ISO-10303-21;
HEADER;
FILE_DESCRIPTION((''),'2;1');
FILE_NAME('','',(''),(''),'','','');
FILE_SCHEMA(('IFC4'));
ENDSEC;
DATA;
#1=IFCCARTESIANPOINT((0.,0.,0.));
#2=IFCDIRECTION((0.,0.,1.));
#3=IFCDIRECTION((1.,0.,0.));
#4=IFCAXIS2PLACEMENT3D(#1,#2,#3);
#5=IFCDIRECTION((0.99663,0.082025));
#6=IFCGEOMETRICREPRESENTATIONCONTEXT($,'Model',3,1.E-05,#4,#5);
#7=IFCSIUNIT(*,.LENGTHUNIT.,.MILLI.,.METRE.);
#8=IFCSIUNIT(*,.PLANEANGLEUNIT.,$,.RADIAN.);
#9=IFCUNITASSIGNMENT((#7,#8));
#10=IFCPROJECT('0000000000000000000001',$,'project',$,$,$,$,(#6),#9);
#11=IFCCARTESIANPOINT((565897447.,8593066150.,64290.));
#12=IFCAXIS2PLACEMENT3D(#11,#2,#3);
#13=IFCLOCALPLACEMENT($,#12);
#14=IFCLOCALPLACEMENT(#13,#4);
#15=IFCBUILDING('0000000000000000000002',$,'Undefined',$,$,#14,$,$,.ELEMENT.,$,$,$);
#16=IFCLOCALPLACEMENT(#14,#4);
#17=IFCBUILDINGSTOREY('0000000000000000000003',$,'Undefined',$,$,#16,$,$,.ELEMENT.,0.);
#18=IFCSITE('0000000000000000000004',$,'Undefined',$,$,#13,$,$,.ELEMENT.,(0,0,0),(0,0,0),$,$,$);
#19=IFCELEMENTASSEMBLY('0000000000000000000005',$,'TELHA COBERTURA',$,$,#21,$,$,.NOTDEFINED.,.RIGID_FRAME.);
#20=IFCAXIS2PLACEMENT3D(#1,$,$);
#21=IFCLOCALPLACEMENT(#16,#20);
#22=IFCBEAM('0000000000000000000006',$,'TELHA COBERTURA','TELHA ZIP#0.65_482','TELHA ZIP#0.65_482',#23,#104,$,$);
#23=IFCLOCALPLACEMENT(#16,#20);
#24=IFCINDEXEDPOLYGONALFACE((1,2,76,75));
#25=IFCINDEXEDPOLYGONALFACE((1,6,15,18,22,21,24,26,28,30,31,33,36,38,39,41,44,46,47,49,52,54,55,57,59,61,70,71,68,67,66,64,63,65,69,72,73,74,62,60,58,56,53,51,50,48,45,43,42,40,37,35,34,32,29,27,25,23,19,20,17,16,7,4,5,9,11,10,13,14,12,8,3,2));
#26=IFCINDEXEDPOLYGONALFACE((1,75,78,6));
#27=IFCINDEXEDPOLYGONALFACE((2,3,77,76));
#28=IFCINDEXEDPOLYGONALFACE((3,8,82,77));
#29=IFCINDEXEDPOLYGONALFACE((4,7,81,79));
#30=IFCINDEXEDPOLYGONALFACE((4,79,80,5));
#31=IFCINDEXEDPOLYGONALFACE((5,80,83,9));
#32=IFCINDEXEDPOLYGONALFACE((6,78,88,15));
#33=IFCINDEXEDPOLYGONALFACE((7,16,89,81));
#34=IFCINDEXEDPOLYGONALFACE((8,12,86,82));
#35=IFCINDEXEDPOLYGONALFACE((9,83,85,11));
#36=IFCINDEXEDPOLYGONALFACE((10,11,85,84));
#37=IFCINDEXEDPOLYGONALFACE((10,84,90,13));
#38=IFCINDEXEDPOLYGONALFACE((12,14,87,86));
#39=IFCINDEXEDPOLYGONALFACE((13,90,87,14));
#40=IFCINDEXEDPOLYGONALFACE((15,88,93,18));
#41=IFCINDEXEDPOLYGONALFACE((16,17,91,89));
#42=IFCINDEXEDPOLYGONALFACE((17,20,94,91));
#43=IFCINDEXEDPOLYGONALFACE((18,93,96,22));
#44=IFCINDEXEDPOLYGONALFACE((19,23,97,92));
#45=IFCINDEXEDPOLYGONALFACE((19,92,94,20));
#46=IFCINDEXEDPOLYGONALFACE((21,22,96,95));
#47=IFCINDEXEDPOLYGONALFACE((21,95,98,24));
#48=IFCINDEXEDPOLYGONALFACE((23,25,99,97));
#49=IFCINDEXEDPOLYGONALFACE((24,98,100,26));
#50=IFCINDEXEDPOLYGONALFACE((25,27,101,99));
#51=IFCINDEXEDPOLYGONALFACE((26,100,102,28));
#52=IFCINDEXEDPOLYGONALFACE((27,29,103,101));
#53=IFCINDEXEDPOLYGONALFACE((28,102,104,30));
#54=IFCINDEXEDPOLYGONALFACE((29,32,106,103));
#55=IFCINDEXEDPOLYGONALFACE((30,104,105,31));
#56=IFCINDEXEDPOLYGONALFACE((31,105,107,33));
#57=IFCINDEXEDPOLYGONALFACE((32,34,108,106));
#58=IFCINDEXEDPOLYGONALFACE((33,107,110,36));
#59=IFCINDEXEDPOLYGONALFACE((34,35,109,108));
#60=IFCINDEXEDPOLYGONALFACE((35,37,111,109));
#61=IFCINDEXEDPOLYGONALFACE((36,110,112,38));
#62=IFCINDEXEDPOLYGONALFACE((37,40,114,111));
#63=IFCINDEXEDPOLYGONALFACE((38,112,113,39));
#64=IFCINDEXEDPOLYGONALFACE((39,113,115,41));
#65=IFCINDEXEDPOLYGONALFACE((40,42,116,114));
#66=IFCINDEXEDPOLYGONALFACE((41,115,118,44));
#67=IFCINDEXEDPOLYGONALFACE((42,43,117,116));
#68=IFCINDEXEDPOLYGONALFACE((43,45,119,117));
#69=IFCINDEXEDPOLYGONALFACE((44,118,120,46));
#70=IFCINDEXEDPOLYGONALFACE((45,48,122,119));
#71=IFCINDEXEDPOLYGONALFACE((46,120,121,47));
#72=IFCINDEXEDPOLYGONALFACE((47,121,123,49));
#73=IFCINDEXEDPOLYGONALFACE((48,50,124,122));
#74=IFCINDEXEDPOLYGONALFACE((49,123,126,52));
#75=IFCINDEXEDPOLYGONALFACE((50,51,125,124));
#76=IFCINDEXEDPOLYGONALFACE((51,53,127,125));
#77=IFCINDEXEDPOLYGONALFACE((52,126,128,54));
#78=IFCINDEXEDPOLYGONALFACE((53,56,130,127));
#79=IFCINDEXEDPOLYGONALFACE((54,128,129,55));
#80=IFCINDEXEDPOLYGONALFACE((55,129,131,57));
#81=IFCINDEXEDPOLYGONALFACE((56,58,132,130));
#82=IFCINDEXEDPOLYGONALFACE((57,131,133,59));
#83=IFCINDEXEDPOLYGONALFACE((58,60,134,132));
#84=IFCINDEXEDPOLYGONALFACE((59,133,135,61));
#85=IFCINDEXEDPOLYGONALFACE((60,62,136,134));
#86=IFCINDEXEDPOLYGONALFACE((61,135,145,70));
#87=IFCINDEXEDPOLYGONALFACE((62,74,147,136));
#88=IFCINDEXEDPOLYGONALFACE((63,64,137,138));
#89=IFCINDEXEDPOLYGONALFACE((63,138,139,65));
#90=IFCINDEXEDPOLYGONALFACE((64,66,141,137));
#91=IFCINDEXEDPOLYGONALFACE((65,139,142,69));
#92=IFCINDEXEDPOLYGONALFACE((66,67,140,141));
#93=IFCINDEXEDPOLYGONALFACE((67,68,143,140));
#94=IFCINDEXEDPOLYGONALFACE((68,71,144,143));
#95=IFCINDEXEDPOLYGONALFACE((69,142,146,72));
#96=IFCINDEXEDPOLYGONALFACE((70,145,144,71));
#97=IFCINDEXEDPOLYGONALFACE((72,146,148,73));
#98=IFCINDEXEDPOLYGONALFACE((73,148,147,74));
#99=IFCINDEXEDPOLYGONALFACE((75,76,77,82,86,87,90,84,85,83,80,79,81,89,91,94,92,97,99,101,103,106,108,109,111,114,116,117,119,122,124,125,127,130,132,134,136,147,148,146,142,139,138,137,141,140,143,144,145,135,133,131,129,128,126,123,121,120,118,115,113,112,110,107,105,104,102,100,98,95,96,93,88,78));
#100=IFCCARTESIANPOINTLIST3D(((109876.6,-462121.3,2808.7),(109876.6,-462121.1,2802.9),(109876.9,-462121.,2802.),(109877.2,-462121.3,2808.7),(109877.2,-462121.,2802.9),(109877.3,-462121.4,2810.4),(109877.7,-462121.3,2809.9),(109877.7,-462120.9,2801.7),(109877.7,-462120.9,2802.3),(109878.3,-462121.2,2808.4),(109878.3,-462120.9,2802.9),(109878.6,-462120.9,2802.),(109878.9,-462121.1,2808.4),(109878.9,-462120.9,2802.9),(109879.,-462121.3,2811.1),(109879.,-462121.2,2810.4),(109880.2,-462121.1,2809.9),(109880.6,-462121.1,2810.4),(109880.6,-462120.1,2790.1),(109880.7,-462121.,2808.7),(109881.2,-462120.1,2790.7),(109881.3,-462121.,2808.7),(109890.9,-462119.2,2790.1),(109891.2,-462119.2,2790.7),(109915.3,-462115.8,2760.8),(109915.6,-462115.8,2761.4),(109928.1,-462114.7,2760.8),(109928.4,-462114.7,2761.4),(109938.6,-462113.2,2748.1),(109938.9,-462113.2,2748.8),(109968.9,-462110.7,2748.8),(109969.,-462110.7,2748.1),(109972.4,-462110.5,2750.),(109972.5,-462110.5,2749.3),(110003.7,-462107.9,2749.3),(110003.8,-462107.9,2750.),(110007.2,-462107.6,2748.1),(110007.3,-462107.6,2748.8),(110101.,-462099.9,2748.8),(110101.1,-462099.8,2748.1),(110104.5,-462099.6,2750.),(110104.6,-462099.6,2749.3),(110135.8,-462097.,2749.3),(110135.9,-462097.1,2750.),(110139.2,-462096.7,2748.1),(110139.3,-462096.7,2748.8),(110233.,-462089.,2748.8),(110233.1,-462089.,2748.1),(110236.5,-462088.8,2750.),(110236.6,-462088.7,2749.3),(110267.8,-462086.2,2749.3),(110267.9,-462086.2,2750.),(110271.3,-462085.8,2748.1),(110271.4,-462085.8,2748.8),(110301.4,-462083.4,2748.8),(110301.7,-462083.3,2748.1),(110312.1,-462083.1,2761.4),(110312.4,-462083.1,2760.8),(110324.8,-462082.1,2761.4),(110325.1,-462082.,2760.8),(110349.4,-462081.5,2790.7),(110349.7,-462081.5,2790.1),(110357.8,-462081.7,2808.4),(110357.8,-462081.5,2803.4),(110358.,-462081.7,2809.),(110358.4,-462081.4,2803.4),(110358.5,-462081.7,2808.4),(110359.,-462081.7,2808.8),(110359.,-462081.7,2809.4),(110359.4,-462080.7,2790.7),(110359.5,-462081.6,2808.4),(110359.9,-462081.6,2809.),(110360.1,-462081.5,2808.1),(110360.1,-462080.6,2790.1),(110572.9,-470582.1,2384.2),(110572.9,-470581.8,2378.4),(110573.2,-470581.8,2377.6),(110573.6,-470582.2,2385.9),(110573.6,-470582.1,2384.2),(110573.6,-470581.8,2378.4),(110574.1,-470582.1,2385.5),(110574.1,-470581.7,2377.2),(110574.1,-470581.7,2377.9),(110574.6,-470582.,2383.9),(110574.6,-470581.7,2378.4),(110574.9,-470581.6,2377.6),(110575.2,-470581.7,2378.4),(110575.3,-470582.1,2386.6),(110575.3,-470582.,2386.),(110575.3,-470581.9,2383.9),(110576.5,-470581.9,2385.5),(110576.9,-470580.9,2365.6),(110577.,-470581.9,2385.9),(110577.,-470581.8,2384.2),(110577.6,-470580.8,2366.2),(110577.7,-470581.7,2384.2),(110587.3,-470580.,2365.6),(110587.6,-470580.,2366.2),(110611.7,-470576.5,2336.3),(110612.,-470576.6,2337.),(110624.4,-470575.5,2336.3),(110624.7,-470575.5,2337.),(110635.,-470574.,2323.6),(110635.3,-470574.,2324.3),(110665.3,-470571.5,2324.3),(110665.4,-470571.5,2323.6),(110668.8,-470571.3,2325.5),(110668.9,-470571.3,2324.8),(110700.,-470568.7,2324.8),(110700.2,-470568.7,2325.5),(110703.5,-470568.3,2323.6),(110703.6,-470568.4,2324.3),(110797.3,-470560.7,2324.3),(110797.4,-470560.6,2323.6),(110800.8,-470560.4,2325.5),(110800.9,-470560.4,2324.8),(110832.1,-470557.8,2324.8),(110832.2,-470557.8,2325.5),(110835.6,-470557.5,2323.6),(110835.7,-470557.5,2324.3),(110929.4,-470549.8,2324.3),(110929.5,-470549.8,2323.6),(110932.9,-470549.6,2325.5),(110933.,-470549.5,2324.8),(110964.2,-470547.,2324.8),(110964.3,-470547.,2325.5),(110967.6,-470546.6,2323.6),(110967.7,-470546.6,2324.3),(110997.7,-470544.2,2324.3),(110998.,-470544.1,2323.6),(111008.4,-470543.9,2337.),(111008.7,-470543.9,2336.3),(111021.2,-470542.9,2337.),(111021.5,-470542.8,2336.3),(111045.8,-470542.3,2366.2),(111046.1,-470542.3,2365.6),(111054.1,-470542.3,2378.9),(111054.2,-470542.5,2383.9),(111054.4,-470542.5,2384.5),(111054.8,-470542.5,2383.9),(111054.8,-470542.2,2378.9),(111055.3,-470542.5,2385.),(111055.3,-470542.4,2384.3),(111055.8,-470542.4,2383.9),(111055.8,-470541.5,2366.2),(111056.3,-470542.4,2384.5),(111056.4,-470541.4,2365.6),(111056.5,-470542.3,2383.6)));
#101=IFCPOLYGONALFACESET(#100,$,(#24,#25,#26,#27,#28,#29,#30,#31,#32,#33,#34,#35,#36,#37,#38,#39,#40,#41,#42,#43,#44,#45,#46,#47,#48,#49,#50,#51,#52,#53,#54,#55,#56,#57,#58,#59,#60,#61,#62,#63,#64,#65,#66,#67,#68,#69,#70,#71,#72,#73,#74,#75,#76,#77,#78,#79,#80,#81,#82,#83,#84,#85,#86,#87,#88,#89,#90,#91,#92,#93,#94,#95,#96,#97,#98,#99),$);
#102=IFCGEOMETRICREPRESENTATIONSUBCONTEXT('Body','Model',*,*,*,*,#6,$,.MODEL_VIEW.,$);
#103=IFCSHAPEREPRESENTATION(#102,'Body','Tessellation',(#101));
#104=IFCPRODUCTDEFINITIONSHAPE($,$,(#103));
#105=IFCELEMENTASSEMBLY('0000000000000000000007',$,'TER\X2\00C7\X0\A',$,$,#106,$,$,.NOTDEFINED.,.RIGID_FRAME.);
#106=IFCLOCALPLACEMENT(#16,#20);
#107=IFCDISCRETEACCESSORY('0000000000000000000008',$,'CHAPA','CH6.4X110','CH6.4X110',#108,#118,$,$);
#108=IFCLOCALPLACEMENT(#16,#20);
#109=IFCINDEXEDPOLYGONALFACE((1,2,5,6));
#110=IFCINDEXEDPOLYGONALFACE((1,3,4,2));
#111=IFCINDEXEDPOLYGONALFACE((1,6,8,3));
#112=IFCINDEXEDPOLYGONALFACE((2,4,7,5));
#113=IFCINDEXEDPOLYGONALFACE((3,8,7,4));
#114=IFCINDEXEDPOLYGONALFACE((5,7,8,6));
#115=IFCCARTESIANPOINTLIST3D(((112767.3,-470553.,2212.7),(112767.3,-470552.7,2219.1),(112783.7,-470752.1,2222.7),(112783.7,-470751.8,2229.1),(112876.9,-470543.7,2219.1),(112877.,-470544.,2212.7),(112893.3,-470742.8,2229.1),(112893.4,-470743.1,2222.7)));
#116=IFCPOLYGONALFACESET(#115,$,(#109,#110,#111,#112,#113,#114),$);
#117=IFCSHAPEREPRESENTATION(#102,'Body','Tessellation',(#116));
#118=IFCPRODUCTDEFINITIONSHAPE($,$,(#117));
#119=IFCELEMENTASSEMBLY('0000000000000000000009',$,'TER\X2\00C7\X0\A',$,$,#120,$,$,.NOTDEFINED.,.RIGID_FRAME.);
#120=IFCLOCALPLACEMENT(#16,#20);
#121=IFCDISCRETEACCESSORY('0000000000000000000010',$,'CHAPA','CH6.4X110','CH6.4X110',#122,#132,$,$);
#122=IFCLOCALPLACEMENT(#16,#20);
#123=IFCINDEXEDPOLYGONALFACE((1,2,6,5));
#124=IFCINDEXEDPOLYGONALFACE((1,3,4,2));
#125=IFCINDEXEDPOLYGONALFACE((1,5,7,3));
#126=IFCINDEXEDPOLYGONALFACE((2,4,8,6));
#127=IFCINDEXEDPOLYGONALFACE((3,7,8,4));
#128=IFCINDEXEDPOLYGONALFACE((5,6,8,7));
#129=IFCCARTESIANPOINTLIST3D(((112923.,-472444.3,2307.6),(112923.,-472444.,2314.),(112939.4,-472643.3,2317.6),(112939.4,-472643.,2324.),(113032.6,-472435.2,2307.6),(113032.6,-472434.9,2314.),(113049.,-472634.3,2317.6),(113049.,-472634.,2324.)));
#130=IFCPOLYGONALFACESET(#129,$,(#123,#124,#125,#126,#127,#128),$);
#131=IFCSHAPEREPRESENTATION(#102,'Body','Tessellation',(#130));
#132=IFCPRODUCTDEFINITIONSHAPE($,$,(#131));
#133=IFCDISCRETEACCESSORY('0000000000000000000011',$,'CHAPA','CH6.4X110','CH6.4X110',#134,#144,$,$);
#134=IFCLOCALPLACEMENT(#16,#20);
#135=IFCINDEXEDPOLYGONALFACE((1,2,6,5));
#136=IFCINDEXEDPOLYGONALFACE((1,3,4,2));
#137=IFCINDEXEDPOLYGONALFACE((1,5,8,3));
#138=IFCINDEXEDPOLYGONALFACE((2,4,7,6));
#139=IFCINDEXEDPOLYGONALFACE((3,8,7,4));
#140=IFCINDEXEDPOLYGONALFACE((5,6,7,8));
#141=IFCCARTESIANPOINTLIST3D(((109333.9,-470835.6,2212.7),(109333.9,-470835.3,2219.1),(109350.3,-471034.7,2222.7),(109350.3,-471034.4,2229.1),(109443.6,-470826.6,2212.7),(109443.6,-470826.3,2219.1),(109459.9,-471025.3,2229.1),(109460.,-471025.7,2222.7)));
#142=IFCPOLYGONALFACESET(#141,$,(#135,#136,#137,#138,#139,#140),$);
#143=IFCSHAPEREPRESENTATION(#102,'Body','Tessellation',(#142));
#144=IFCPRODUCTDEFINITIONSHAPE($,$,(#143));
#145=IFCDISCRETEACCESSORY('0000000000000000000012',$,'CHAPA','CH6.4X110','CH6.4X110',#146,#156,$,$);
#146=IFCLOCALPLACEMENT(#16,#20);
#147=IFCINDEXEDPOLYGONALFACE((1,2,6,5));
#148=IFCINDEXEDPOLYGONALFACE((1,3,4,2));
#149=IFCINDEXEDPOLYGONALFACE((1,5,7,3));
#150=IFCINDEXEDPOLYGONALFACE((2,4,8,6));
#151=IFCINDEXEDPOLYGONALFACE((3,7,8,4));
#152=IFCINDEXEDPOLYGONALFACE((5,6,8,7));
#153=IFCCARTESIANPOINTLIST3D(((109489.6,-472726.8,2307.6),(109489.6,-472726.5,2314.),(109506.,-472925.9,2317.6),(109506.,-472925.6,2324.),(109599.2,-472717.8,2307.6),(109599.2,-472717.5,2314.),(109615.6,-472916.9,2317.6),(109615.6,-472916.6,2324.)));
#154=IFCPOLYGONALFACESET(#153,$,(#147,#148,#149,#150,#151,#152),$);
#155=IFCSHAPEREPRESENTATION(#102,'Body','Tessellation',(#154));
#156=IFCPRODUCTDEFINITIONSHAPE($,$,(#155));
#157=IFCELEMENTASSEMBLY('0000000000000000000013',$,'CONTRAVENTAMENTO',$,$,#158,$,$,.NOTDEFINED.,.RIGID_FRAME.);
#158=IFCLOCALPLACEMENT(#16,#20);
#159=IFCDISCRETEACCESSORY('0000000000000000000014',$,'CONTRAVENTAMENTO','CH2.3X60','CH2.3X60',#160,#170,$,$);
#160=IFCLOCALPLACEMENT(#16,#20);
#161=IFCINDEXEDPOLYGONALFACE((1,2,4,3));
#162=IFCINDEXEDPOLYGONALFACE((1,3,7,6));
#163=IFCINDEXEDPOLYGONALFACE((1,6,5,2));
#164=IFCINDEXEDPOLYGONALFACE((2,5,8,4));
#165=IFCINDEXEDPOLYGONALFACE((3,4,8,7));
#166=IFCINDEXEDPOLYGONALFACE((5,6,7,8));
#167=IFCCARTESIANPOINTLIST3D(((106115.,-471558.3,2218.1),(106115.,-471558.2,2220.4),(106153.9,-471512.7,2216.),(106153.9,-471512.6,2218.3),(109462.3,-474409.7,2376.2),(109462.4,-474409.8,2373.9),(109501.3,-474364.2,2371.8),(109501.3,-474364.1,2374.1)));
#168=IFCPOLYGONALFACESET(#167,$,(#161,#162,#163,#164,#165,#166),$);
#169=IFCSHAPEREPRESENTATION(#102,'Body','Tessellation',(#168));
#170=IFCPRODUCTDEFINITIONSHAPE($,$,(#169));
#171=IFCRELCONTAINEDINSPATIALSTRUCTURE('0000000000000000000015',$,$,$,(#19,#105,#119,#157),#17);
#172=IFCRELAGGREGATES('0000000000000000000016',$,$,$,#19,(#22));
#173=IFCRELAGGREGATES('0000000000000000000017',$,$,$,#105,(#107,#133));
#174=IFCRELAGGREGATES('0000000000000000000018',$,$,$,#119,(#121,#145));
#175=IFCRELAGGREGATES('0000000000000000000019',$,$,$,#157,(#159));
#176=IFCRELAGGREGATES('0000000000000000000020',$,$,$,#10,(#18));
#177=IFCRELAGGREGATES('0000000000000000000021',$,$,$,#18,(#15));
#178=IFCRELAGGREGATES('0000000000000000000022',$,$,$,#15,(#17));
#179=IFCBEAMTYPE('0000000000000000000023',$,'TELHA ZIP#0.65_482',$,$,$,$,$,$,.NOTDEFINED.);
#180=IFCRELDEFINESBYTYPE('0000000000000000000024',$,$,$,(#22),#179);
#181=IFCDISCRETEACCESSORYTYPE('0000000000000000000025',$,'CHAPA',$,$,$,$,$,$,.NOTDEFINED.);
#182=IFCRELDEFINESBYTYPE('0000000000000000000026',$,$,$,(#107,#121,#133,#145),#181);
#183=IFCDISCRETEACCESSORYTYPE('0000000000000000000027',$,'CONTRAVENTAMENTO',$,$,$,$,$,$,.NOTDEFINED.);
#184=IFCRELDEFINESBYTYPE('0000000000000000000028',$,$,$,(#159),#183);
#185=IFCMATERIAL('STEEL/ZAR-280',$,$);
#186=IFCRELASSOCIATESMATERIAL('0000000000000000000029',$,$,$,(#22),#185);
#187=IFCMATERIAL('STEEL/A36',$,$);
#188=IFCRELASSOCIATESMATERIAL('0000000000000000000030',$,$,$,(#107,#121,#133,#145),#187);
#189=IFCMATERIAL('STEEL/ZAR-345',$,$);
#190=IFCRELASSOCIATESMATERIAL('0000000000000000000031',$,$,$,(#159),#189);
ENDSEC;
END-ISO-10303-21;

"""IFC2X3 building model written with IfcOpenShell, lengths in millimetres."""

from ifc_helpers import new_model, si_unit, direction, frame, origin_with_axes, place, context, subcontext, project, spatial, polyline, outline, extrude, material, type_object, element, aggregate, save


model = new_model("IFC2X3")

# Units and contexts
model_context = context("Model", 3, precision=1e-05, world=origin_with_axes(), true_north=direction((0.99663, 0.082025)))
body_context = subcontext(model_context, "Body", "Model", "MODEL_VIEW")
ifc_project = project(units=[si_unit("LENGTHUNIT", "METRE", prefix="MILLI"), si_unit("PLANEANGLEUNIT", "RADIAN")], contexts=[model_context])

# Site, building, storey
site_placement = place(None, frame((565897447.0, 8593066150.0, 64290.0), z_axis=(0.0, 0.0, 1.0), x_axis=(1.0, 0.0, 0.0)))
site = spatial("IfcSite", under=ifc_project, at=site_placement, Name="Undefined", CompositionType="ELEMENT", RefLatitude=(0, 0, 0), RefLongitude=(0, 0, 0))
building_placement = place(site_placement, origin_with_axes())
building = spatial("IfcBuilding", under=site, at=building_placement, Name="Undefined", CompositionType="ELEMENT")
storey_placement = place(building_placement, origin_with_axes())
storey = spatial("IfcBuildingStorey", under=building, at=storey_placement, Name="Undefined", CompositionType="ELEMENT", Elevation=0.0)

# Shared definitions
ifc_material_1 = material(Name="STEEL/A36")

# Element assembly, beam
ifc_material_2 = material(Name="STEEL/ZAR-280")
beam_type_1 = type_object("IfcBeamType", Name="TELHA ZIP#0.65_482", PredefinedType="NOTDEFINED")
assembly_1_placement = place(storey_placement, origin_with_axes())
assembly_1 = element("IfcElementAssembly", 1, at=assembly_1_placement, inside=storey, Name="TELHA COBERTURA", AssemblyPlace="NOTDEFINED", PredefinedType="RIGID_FRAME")
beam_1_placement = place(assembly_1_placement, frame((110814.6, -470560.8, 2354.8), z_axis=(0.004096, -0.049769, 0.998752), x_axis=(-0.081923, 0.995387, 0.049938)))
beam_1 = element("IfcBeam", 2, at=beam_1_placement, type_object=beam_type_1, material=ifc_material_2, Name="TELHA COBERTURA", Description="TELHA ZIP#0.65_482", ObjectType="TELHA ZIP#0.65_482", context=body_context, shape_type="SweptSolid", body=[
    extrude(outline(polyline([(240.5, 29.7), (241.4, 30.2), (242.4, 29.7), (242.6, 28.9), (242.6, 10.8), (232.2, 10.8), (207.6, -18.5), (194.9, -18.5), (184.2, -31.2), (153.7, -31.2), (150.2, -30.0), (118.9, -30.0), (115.4, -31.2), (21.2, -31.2), (17.7, -30.0), (-13.6, -30.0), (-17.1, -31.2), (-111.3, -31.2), (-114.8, -30.0), (-146.1, -30.0), (-149.6, -31.2), (-180.1, -31.2), (-190.8, -18.5), (-203.6, -18.5), (-228.1, 10.8), (-238.5, 10.8), (-238.5, 29.5), (-239.0, 30.7), (-240.2, 31.2), (-241.4, 30.7), (-241.9, 29.5), (-241.9, 23.6), (-241.4, 23.1), (-240.9, 23.6), (-240.9, 29.1), (-240.2, 29.1), (-240.2, 23.6), (-240.6, 22.8), (-241.4, 22.4), (-242.3, 22.8), (-242.6, 23.6), (-242.6, 29.5), (-241.9, 31.2), (-240.2, 31.9), (-238.5, 31.2), (-237.9, 29.5), (-237.9, 11.4), (-227.8, 11.4), (-203.2, -17.9), (-190.4, -17.9), (-179.8, -30.5), (-149.7, -30.5), (-146.2, -29.4), (-114.7, -29.4), (-111.2, -30.5), (-17.2, -30.5), (-13.7, -29.4), (17.8, -29.4), (21.3, -30.5), (115.3, -30.5), (118.8, -29.4), (150.3, -29.4), (153.8, -30.5), (183.9, -30.5), (194.6, -17.9), (207.4, -17.9), (231.9, 11.4), (241.9, 11.4), (241.9, 29.1), (241.4, 29.5), (240.9, 29.1), (240.9, 24.1), (240.2, 24.1), (240.2, 29.2), (240.5, 29.7)])), frame((8500.0, 0.0, 0.0), z_axis=(-1.0, 0.0, 0.0), x_axis=(0.0, -1.0, 0.0)), (0.0, 0.0, 1.0), 8500.0),
])
aggregate(assembly_1, [beam_1])

# Shared definitions
discrete_accessory_type_1 = type_object("IfcDiscreteAccessoryType", Name="CHAPA")

# Element assemblies, discrete accessories
assembly_2_placement = place(storey_placement, origin_with_axes())
assembly_2 = element("IfcElementAssembly", 3, at=assembly_2_placement, inside=storey, Name="TERÇA", AssemblyPlace="NOTDEFINED", PredefinedType="RIGID_FRAME")
discrete_accessory_1_placement = place(assembly_2_placement, frame((112838.5, -470747.4, 2225.9), z_axis=(-0.004096, 0.049769, 0.998752), x_axis=(-0.081923, 0.995387, -0.049938)))
discrete_accessory_1 = element("IfcDiscreteAccessory", 4, at=discrete_accessory_1_placement, type_object=discrete_accessory_type_1, material=ifc_material_1, Name="CHAPA", Description="CH6.4X110", ObjectType="CH6.4X110", context=body_context, shape_type="SweptSolid", body=[
    extrude(outline(polyline([(200.0, 55.0), (200.0, -55.0), (0.0, -55.0), (0.0, 55.0), (200.0, 55.0)])), frame((0.0, 0.0, -3.2), z_axis=(0.0, 0.0, 1.0), x_axis=(1.0, 0.0, 0.0)), (0.0, 0.0, 1.0), 6.4),
])
assembly_3_placement = place(storey_placement, origin_with_axes())
assembly_3 = element("IfcElementAssembly", 5, at=assembly_3_placement, inside=storey, Name="TERÇA", AssemblyPlace="NOTDEFINED", PredefinedType="RIGID_FRAME")
discrete_accessory_2_placement = place(assembly_3_placement, frame((112994.2, -472638.7, 2320.8), z_axis=(-0.004096, 0.049769, 0.998752), x_axis=(-0.081923, 0.995387, -0.049938)))
discrete_accessory_2 = element("IfcDiscreteAccessory", 6, at=discrete_accessory_2_placement, type_object=discrete_accessory_type_1, material=ifc_material_1, Name="CHAPA", Description="CH6.4X110", ObjectType="CH6.4X110", context=body_context, shape_type="SweptSolid", body=[
    extrude(outline(polyline([(200.0, 55.0), (200.0, -55.0), (0.0, -55.0), (0.0, 55.0), (200.0, 55.0)])), frame((0.0, 0.0, -3.2), z_axis=(0.0, 0.0, 1.0), x_axis=(1.0, 0.0, 0.0)), (0.0, 0.0, 1.0), 6.4),
])

# Discrete accessories
discrete_accessory_3_placement = place(assembly_2_placement, frame((109405.1, -471030.0, 2225.9), z_axis=(-0.004096, 0.049769, 0.998752), x_axis=(-0.081923, 0.995387, -0.049938)))
discrete_accessory_3 = element("IfcDiscreteAccessory", 7, at=discrete_accessory_3_placement, type_object=discrete_accessory_type_1, material=ifc_material_1, Name="CHAPA", Description="CH6.4X110", ObjectType="CH6.4X110", context=body_context, shape_type="SweptSolid", body=[
    extrude(outline(polyline([(200.0, 55.0), (200.0, -55.0), (0.0, -55.0), (0.0, 55.0), (200.0, 55.0)])), frame((0.0, 0.0, -3.2), z_axis=(0.0, 0.0, 1.0), x_axis=(1.0, 0.0, 0.0)), (0.0, 0.0, 1.0), 6.4),
])
aggregate(assembly_2, [discrete_accessory_1, discrete_accessory_3])
discrete_accessory_4_placement = place(assembly_3_placement, frame((109560.8, -472921.3, 2320.8), z_axis=(-0.004096, 0.049769, 0.998752), x_axis=(-0.081923, 0.995387, -0.049938)))
discrete_accessory_4 = element("IfcDiscreteAccessory", 8, at=discrete_accessory_4_placement, type_object=discrete_accessory_type_1, material=ifc_material_1, Name="CHAPA", Description="CH6.4X110", ObjectType="CH6.4X110", context=body_context, shape_type="SweptSolid", body=[
    extrude(outline(polyline([(200.0, 55.0), (200.0, -55.0), (0.0, -55.0), (0.0, 55.0), (200.0, 55.0)])), frame((0.0, 0.0, -3.2), z_axis=(0.0, 0.0, 1.0), x_axis=(1.0, 0.0, 0.0)), (0.0, 0.0, 1.0), 6.4),
])
aggregate(assembly_3, [discrete_accessory_2, discrete_accessory_4])

# Element assembly, discrete accessory
assembly_4_placement = place(storey_placement, origin_with_axes())
assembly_4 = element("IfcElementAssembly", 9, at=assembly_4_placement, inside=storey, Name="CONTRAVENTAMENTO", AssemblyPlace="NOTDEFINED", PredefinedType="RIGID_FRAME")
ifc_material_3 = material(Name="STEEL/ZAR-345")
discrete_accessory_type_2 = type_object("IfcDiscreteAccessoryType", Name="CONTRAVENTAMENTO")
discrete_accessory_5_placement = place(assembly_4_placement, frame((109481.8, -474386.9, 2374.0), z_axis=(0.004096, -0.049769, -0.998752), x_axis=(-0.76077, 0.648055, -0.035414)))
discrete_accessory_5 = element("IfcDiscreteAccessory", 10, at=discrete_accessory_5_placement, type_object=discrete_accessory_type_2, material=ifc_material_3, Name="CONTRAVENTAMENTO", Description="CH2.3X60", ObjectType="CH2.3X60", context=body_context, shape_type="SweptSolid", body=[
    extrude(outline(polyline([(4400.0, 30.0), (4400.0, -30.0), (0.0, -30.0), (0.0, 30.0), (4400.0, 30.0)])), frame((0.0, 0.0, -1.2), z_axis=(0.0, 0.0, 1.0), x_axis=(1.0, 0.0, 0.0)), (0.0, 0.0, 1.0), 2.3),
])
aggregate(assembly_4, [discrete_accessory_5])

save(model, "model.ifc")
